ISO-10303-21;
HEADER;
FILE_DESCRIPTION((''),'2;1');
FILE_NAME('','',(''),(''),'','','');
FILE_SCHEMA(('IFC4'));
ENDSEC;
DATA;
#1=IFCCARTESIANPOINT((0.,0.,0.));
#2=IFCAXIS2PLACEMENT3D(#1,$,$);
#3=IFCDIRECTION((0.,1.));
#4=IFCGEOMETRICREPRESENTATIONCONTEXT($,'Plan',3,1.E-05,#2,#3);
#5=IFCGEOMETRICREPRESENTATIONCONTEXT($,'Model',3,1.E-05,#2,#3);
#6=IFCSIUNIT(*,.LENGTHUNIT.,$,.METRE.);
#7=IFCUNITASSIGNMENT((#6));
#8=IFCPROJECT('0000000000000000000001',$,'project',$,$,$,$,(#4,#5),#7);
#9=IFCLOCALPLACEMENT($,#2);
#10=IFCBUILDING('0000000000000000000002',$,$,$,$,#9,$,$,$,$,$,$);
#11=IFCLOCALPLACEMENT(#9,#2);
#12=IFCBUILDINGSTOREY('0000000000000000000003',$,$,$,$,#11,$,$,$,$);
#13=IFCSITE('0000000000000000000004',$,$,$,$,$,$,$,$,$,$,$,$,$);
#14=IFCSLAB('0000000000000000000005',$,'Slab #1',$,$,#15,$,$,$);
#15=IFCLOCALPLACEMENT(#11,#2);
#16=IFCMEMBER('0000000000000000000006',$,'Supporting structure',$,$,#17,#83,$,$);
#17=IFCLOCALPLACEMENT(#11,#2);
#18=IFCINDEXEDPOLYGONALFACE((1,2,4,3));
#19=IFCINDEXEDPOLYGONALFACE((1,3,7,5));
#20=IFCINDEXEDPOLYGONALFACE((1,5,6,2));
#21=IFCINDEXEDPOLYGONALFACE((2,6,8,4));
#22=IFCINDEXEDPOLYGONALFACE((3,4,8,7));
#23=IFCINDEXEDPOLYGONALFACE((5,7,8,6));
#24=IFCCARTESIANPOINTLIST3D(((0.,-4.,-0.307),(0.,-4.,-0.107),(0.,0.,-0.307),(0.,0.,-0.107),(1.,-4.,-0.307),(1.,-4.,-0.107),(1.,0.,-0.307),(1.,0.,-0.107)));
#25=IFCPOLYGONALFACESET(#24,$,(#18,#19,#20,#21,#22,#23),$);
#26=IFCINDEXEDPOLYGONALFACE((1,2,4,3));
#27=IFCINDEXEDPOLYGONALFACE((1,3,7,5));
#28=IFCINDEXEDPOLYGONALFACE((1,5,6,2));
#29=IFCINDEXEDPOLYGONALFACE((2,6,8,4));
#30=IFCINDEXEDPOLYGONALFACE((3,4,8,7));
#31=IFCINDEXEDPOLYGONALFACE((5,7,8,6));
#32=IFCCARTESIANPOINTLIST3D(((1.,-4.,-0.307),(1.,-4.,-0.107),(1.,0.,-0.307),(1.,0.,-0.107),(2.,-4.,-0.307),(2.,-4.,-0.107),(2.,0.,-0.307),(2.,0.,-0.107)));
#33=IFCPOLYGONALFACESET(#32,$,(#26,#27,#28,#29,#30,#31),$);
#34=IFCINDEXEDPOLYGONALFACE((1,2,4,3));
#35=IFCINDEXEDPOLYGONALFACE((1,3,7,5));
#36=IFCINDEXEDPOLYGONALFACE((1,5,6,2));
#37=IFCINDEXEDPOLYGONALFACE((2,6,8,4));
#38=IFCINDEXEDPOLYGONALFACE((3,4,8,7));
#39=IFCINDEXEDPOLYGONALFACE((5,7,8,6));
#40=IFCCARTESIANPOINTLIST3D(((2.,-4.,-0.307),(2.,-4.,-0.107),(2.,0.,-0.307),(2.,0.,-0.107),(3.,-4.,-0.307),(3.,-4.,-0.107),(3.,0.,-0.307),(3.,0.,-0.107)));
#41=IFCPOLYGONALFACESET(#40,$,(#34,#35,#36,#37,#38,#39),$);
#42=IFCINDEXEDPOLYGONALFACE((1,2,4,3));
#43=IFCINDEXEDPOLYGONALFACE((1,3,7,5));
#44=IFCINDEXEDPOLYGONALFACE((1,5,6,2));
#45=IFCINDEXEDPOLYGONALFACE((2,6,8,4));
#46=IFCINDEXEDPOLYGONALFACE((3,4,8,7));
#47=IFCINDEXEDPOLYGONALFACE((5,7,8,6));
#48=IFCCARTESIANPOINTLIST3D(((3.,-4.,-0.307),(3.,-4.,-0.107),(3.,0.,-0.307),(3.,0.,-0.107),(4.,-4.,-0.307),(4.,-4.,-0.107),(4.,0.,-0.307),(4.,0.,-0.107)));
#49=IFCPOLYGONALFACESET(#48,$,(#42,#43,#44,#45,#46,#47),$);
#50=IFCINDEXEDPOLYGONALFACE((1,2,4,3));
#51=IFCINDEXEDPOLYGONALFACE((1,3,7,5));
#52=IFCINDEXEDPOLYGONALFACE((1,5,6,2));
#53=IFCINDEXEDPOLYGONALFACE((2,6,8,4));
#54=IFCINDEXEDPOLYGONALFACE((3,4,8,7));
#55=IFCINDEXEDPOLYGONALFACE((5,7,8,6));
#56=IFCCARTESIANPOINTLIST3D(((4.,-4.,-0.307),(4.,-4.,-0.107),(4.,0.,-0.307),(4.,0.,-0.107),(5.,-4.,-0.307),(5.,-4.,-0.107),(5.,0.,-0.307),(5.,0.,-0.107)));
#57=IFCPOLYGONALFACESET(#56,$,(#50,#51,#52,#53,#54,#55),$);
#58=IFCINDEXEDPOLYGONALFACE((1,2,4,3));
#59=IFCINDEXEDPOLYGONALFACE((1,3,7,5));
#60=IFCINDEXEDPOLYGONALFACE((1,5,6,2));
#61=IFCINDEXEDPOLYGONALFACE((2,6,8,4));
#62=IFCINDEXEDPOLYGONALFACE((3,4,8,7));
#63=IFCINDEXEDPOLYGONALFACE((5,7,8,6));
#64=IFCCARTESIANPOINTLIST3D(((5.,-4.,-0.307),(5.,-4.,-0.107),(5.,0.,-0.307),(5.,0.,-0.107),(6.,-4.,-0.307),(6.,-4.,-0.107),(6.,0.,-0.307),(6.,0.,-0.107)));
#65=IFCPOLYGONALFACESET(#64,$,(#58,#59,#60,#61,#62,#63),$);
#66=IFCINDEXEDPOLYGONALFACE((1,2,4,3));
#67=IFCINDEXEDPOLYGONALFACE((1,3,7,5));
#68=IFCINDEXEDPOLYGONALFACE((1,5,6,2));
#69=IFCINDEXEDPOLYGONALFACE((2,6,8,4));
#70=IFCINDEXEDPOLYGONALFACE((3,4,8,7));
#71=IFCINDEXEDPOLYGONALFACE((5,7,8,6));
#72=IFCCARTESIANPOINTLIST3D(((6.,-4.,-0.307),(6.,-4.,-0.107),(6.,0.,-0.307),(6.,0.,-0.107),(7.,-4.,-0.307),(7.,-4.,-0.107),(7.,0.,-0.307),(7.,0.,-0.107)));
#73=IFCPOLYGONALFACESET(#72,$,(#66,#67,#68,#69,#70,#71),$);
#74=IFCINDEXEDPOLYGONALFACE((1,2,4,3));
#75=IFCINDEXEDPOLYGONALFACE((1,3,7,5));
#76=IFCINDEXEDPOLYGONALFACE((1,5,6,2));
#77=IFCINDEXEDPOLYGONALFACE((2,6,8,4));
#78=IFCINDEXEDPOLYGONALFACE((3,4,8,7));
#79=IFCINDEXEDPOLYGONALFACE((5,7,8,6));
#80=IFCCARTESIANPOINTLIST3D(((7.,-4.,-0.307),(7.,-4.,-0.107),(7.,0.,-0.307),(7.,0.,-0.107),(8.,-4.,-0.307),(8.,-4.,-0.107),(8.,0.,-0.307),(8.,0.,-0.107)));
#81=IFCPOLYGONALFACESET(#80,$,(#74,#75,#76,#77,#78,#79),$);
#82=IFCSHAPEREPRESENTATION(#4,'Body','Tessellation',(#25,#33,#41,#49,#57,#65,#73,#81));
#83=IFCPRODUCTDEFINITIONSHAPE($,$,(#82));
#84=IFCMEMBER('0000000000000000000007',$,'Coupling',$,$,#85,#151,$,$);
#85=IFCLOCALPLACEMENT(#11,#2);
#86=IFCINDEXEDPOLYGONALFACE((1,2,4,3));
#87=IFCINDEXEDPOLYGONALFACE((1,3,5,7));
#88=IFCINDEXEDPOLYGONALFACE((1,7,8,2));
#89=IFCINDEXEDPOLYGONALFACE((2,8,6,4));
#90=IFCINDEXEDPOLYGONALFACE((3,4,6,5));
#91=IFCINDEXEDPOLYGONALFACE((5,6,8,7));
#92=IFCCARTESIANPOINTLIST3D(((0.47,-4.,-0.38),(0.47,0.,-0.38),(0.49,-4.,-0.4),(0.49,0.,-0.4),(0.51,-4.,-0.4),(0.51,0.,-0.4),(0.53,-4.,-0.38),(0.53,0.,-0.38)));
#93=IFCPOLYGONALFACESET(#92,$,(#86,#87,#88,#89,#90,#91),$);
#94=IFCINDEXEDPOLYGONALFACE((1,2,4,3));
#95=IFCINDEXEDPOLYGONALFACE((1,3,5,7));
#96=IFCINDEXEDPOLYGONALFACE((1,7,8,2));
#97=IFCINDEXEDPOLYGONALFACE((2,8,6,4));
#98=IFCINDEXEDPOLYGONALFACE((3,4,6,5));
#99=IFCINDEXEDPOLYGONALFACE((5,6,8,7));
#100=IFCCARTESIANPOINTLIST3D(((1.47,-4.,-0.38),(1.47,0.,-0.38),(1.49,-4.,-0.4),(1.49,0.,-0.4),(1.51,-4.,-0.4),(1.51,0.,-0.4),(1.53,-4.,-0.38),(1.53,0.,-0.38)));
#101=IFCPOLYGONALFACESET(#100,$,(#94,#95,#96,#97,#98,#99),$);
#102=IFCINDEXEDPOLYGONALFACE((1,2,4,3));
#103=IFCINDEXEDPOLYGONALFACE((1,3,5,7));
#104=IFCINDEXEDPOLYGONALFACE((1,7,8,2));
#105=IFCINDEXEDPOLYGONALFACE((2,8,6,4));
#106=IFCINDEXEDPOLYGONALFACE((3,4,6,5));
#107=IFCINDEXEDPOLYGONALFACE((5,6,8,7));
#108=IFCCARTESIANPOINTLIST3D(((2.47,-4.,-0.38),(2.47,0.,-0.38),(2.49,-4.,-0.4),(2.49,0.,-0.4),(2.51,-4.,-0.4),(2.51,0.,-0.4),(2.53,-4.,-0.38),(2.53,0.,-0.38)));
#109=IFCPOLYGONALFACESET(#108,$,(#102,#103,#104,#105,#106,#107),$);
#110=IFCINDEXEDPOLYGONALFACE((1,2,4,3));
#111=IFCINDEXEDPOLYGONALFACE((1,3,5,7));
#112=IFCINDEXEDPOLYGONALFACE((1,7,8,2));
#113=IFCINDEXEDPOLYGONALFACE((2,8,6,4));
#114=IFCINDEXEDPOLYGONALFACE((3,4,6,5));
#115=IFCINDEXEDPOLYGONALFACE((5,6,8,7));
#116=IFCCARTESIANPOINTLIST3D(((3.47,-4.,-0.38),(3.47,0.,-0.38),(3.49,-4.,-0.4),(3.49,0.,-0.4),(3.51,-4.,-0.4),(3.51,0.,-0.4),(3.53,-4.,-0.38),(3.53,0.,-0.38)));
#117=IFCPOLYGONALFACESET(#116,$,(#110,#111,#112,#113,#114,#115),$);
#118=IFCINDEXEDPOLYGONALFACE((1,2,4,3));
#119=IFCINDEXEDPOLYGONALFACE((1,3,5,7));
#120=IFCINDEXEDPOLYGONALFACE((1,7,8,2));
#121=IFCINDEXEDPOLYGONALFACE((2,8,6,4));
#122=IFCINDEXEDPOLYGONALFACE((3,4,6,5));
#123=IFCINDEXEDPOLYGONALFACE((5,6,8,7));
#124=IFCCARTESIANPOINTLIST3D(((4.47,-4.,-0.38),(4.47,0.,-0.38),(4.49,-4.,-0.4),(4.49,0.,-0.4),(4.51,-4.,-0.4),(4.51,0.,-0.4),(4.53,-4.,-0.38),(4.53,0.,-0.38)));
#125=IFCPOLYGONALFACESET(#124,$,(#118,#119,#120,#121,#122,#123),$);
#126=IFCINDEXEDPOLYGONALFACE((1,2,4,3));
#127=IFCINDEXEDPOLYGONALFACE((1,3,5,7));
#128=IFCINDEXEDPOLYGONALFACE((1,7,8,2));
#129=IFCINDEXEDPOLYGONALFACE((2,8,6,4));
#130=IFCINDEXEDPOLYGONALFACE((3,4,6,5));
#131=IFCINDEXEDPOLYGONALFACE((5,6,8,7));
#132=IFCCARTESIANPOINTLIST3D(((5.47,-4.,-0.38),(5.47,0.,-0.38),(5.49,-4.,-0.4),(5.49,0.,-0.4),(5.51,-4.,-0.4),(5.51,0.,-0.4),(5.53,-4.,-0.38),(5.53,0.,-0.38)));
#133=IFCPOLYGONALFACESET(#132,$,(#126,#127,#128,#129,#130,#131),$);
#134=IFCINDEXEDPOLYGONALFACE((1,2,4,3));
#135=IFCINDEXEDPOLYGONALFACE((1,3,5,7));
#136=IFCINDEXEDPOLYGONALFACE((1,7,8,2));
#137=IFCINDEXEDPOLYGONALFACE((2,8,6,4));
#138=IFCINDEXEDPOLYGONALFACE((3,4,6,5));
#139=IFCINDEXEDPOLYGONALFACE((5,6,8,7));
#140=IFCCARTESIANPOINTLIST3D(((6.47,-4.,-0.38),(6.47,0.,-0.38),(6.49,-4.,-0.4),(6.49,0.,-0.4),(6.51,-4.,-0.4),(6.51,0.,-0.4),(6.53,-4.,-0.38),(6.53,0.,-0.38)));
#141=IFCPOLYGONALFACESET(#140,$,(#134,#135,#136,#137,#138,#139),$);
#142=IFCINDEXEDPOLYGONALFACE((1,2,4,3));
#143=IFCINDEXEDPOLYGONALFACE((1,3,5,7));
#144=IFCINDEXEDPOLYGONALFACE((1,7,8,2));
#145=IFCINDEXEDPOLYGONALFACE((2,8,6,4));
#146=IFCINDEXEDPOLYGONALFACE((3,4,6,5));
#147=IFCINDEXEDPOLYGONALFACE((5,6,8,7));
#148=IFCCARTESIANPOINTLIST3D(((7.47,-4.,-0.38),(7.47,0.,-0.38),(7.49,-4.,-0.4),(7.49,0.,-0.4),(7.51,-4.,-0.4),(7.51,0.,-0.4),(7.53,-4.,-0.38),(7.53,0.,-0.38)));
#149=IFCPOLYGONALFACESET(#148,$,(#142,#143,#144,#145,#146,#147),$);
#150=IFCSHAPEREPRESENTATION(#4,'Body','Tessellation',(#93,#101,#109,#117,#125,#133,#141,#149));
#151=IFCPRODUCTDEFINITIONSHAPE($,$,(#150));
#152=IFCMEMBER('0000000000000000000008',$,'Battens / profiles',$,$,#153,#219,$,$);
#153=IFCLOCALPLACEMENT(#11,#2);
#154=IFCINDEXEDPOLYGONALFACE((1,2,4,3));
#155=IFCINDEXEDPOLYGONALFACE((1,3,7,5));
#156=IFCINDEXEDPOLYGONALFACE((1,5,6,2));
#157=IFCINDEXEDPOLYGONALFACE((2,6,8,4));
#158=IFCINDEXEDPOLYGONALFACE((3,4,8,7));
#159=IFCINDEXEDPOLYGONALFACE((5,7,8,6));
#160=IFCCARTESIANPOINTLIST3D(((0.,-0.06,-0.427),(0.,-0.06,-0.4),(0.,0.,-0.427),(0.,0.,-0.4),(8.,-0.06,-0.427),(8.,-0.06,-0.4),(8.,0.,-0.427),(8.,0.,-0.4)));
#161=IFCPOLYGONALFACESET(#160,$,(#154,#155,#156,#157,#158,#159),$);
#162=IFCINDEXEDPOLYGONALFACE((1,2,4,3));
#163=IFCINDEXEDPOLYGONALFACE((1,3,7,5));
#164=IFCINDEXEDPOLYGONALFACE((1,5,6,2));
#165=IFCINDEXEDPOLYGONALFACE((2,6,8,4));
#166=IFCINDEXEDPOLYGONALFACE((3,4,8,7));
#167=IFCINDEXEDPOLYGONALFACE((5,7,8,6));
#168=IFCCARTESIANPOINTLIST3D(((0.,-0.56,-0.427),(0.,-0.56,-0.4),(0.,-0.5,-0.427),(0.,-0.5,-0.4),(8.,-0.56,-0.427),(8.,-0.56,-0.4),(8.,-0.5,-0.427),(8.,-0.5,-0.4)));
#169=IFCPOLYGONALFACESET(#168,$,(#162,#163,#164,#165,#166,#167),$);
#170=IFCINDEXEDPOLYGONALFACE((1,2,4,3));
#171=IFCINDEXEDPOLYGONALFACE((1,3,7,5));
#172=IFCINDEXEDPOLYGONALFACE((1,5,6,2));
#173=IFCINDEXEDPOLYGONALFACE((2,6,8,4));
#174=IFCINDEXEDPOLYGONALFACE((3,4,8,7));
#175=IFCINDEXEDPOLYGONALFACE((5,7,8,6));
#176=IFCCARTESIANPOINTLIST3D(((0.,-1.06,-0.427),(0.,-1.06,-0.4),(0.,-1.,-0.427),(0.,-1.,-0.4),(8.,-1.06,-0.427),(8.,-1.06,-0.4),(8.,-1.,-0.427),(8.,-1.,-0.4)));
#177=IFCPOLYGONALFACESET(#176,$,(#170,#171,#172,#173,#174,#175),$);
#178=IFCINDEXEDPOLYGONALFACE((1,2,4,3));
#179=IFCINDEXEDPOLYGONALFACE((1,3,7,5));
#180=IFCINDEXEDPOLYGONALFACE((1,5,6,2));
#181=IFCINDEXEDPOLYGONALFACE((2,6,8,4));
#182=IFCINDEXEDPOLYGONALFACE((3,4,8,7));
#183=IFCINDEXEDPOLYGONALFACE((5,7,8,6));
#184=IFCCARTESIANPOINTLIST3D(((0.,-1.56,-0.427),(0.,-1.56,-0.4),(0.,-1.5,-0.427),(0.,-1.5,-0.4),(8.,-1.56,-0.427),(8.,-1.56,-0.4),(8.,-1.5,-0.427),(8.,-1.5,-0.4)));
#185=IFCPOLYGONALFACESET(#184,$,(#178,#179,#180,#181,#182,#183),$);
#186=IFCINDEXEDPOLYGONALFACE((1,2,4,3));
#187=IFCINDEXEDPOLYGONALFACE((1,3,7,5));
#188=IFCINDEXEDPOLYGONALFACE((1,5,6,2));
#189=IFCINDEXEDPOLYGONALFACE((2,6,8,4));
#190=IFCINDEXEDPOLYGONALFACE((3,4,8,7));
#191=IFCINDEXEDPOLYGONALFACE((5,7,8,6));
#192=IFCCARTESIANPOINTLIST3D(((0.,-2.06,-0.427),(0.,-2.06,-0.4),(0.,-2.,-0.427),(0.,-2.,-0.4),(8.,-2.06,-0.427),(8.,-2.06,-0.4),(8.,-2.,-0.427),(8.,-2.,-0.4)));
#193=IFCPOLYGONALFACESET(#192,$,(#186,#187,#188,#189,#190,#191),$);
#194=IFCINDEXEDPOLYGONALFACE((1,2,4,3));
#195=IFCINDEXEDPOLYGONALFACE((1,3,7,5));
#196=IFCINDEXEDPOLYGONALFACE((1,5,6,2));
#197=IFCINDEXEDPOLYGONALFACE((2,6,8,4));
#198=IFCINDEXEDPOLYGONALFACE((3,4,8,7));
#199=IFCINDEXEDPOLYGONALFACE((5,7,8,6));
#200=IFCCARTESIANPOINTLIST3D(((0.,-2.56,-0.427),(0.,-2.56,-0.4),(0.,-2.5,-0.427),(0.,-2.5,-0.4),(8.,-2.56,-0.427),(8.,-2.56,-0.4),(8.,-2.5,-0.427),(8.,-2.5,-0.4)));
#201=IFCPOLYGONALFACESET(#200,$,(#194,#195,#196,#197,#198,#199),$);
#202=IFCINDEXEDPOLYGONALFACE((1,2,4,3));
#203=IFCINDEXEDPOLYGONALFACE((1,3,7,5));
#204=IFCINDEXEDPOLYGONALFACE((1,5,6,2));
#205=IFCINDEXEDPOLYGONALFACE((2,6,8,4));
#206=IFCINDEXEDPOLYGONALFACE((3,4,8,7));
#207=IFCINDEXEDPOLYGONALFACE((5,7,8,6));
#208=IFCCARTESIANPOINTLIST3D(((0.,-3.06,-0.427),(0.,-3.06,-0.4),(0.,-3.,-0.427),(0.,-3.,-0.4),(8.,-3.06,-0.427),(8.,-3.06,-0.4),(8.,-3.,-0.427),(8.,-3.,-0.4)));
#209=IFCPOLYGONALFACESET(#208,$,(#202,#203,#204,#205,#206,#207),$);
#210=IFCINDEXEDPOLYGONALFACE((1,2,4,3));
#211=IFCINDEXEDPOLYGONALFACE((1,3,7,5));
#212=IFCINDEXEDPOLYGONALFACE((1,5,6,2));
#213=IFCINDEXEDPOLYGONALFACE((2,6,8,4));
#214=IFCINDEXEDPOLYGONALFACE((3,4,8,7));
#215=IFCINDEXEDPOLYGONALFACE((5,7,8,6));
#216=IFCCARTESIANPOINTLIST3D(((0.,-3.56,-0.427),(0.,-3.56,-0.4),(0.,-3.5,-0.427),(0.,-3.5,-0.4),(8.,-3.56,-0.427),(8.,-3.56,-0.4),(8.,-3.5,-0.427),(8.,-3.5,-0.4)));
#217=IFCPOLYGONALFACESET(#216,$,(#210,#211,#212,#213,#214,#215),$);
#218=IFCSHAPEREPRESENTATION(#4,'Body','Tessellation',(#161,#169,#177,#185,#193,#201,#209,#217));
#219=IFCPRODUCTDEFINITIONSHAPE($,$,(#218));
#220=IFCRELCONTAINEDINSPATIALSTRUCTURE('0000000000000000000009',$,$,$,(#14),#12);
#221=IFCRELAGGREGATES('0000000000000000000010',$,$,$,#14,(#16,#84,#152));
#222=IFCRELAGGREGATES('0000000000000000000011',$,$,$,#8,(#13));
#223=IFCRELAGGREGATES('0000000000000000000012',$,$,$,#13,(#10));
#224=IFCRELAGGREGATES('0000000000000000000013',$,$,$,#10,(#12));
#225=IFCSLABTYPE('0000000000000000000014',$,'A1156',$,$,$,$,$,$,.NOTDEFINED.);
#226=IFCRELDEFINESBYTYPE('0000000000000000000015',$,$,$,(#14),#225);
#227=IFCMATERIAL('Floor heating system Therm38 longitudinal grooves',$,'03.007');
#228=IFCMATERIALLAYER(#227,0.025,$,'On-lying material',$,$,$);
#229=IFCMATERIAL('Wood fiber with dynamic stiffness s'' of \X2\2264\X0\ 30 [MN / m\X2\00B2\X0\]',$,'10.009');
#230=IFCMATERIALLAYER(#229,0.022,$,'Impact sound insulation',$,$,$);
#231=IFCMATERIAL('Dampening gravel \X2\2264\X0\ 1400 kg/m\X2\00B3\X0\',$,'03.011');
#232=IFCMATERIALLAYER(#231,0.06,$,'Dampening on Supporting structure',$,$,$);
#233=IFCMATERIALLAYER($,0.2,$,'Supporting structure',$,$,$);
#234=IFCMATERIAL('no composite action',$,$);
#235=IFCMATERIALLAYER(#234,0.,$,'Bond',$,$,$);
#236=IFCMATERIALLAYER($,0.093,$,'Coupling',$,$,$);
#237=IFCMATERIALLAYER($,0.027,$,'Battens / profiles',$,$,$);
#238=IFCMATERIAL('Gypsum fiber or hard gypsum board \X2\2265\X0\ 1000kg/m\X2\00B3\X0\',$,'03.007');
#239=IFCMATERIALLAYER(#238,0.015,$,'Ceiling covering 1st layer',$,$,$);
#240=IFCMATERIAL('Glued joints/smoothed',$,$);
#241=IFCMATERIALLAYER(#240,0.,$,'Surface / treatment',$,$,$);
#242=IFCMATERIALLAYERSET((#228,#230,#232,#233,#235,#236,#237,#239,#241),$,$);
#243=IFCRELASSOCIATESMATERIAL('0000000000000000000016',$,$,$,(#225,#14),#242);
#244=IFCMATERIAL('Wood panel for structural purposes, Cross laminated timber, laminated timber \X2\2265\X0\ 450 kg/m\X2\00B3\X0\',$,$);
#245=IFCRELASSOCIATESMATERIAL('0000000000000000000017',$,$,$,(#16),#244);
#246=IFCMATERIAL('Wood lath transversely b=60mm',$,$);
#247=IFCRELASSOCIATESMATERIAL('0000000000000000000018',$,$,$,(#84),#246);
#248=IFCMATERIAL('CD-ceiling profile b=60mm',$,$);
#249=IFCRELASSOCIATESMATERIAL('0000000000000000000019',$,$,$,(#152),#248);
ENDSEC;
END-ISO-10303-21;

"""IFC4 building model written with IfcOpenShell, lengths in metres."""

from ifc_helpers import new_model, si_unit, direction, frame, frame_2d, origin, place, context, project, spatial, polyline, rectangle, outline, extrude, material, layer, layer_set, type_object, element, aggregate, save


model = new_model("IFC4")

# Units and contexts
plan_context = context("Plan", 3, precision=1e-05, world=origin(), true_north=direction((0.0, 1.0)))
model_context = context("Model", 3, precision=1e-05, world=origin(), true_north=direction((0.0, 1.0)))
ifc_project = project(units=[si_unit("LENGTHUNIT", "METRE")], contexts=[plan_context, model_context])

# Site, building, storey
site = spatial("IfcSite", under=ifc_project)
building_placement = place(None, origin())
building = spatial("IfcBuilding", under=site, at=building_placement)
storey_placement = place(building_placement, origin())
storey = spatial("IfcBuildingStorey", under=building, at=storey_placement)

# Slab, members
ifc_material_1 = material(Name="Floor heating system Therm38 longitudinal grooves", Category="03.007")
ifc_layer_1 = layer(ifc_material_1, 0.025, Name="On-lying material")
ifc_material_2 = material(Name="Wood fiber with dynamic stiffness s' of ≤ 30 [MN / m²]", Category="10.009")
ifc_layer_2 = layer(ifc_material_2, 0.022, Name="Impact sound insulation")
ifc_material_3 = material(Name="Dampening gravel ≤ 1400 kg/m³", Category="03.011")
ifc_layer_3 = layer(ifc_material_3, 0.06, Name="Dampening on Supporting structure")
ifc_layer_4 = layer(None, 0.2, Name="Supporting structure")
ifc_material_4 = material(Name="no composite action")
ifc_layer_5 = layer(ifc_material_4, 0.0, Name="Bond")
ifc_layer_6 = layer(None, 0.093, Name="Coupling")
ifc_layer_7 = layer(None, 0.027, Name="Battens / profiles")
ifc_material_5 = material(Name="Gypsum fiber or hard gypsum board ≥ 1000kg/m³", Category="03.007")
ifc_layer_8 = layer(ifc_material_5, 0.015, Name="Ceiling covering 1st layer")
ifc_material_6 = material(Name="Glued joints/smoothed")
ifc_layer_9 = layer(ifc_material_6, 0.0, Name="Surface / treatment")
ifc_layer_set = layer_set([ifc_layer_1, ifc_layer_2, ifc_layer_3, ifc_layer_4, ifc_layer_5, ifc_layer_6, ifc_layer_7, ifc_layer_8, ifc_layer_9])
slab_type = type_object("IfcSlabType", Name="A1156", PredefinedType="NOTDEFINED", material=ifc_layer_set)
slab_placement = place(None, frame((0.0, 0.0, 0.0), z_axis=(0.0, 0.0, -1.0), x_axis=(1.0, 0.0, 0.0)))
slab = element("IfcSlab", 1, at=slab_placement, inside=storey, type_object=slab_type, material=ifc_layer_set, Name="Slab #1")
ifc_material_7 = material(Name="Wood panel for structural purposes, Cross laminated timber, laminated timber ≥ 450 kg/m³")
member_1_placement = place(slab_placement, origin())
member_1 = element("IfcMember", 2, at=member_1_placement, material=ifc_material_7, Name="Supporting structure", context=plan_context, shape_type="SweptSolid", body=[
    extrude(rectangle(XDim=1.0, YDim=0.2, at=frame_2d((0.5, 0.1), x_axis=(1.0, 0.0))), frame((0.0, 4.0, 0.107), z_axis=(0.0, -1.0, 0.0), x_axis=(1.0, 0.0, 0.0)), (0.0, 0.0, 1.0), 4.0),
    extrude(rectangle(XDim=1.0, YDim=0.2, at=frame_2d((0.5, 0.1), x_axis=(1.0, 0.0))), frame((1.0, 4.0, 0.107), z_axis=(0.0, -1.0, 0.0), x_axis=(1.0, 0.0, 0.0)), (0.0, 0.0, 1.0), 4.0),
    extrude(rectangle(XDim=1.0, YDim=0.2, at=frame_2d((0.5, 0.1), x_axis=(1.0, 0.0))), frame((2.0, 4.0, 0.107), z_axis=(0.0, -1.0, 0.0), x_axis=(1.0, 0.0, 0.0)), (0.0, 0.0, 1.0), 4.0),
    extrude(rectangle(XDim=1.0, YDim=0.2, at=frame_2d((0.5, 0.1), x_axis=(1.0, 0.0))), frame((3.0, 4.0, 0.107), z_axis=(0.0, -1.0, 0.0), x_axis=(1.0, 0.0, 0.0)), (0.0, 0.0, 1.0), 4.0),
    extrude(rectangle(XDim=1.0, YDim=0.2, at=frame_2d((0.5, 0.1), x_axis=(1.0, 0.0))), frame((4.0, 4.0, 0.107), z_axis=(0.0, -1.0, 0.0), x_axis=(1.0, 0.0, 0.0)), (0.0, 0.0, 1.0), 4.0),
    extrude(rectangle(XDim=1.0, YDim=0.2, at=frame_2d((0.5, 0.1), x_axis=(1.0, 0.0))), frame((5.0, 4.0, 0.107), z_axis=(0.0, -1.0, 0.0), x_axis=(1.0, 0.0, 0.0)), (0.0, 0.0, 1.0), 4.0),
    extrude(rectangle(XDim=1.0, YDim=0.2, at=frame_2d((0.5, 0.1), x_axis=(1.0, 0.0))), frame((6.0, 4.0, 0.107), z_axis=(0.0, -1.0, 0.0), x_axis=(1.0, 0.0, 0.0)), (0.0, 0.0, 1.0), 4.0),
    extrude(rectangle(XDim=1.0, YDim=0.2, at=frame_2d((0.5, 0.1), x_axis=(1.0, 0.0))), frame((7.0, 4.0, 0.107), z_axis=(0.0, -1.0, 0.0), x_axis=(1.0, 0.0, 0.0)), (0.0, 0.0, 1.0), 4.0),
])
ifc_material_8 = material(Name="Wood lath transversely b=60mm")
member_2_placement = place(slab_placement, origin())
member_2 = element("IfcMember", 3, at=member_2_placement, material=ifc_material_8, Name="Coupling", context=plan_context, shape_type="SweptSolid", body=[
    extrude(outline(polyline([(0.0, 0.0), (0.06, 0.0), (0.04, 0.02), (0.02, 0.02), (0.0, 0.0)])), frame((0.47, 4.0, 0.38), z_axis=(0.0, -1.0, 0.0), x_axis=(1.0, 0.0, 0.0)), (0.0, 0.0, 1.0), 4.0),
    extrude(outline(polyline([(0.0, 0.0), (0.06, 0.0), (0.04, 0.02), (0.02, 0.02), (0.0, 0.0)])), frame((1.47, 4.0, 0.38), z_axis=(0.0, -1.0, 0.0), x_axis=(1.0, 0.0, 0.0)), (0.0, 0.0, 1.0), 4.0),
    extrude(outline(polyline([(0.0, 0.0), (0.06, 0.0), (0.04, 0.02), (0.02, 0.02), (0.0, 0.0)])), frame((2.47, 4.0, 0.38), z_axis=(0.0, -1.0, 0.0), x_axis=(1.0, 0.0, 0.0)), (0.0, 0.0, 1.0), 4.0),
    extrude(outline(polyline([(0.0, 0.0), (0.06, 0.0), (0.04, 0.02), (0.02, 0.02), (0.0, 0.0)])), frame((3.47, 4.0, 0.38), z_axis=(0.0, -1.0, 0.0), x_axis=(1.0, 0.0, 0.0)), (0.0, 0.0, 1.0), 4.0),
    extrude(outline(polyline([(0.0, 0.0), (0.06, 0.0), (0.04, 0.02), (0.02, 0.02), (0.0, 0.0)])), frame((4.47, 4.0, 0.38), z_axis=(0.0, -1.0, 0.0), x_axis=(1.0, 0.0, 0.0)), (0.0, 0.0, 1.0), 4.0),
    extrude(outline(polyline([(0.0, 0.0), (0.06, 0.0), (0.04, 0.02), (0.02, 0.02), (0.0, 0.0)])), frame((5.47, 4.0, 0.38), z_axis=(0.0, -1.0, 0.0), x_axis=(1.0, 0.0, 0.0)), (0.0, 0.0, 1.0), 4.0),
    extrude(outline(polyline([(0.0, 0.0), (0.06, 0.0), (0.04, 0.02), (0.02, 0.02), (0.0, 0.0)])), frame((6.47, 4.0, 0.38), z_axis=(0.0, -1.0, 0.0), x_axis=(1.0, 0.0, 0.0)), (0.0, 0.0, 1.0), 4.0),
    extrude(outline(polyline([(0.0, 0.0), (0.06, 0.0), (0.04, 0.02), (0.02, 0.02), (0.0, 0.0)])), frame((7.47, 4.0, 0.38), z_axis=(0.0, -1.0, 0.0), x_axis=(1.0, 0.0, 0.0)), (0.0, 0.0, 1.0), 4.0),
])
ifc_material_9 = material(Name="CD-ceiling profile b=60mm")
member_3_placement = place(slab_placement, origin())
member_3 = element("IfcMember", 4, at=member_3_placement, material=ifc_material_9, Name="Battens / profiles", context=plan_context, shape_type="SweptSolid", body=[
    extrude(rectangle(XDim=0.06, YDim=0.027, at=frame_2d((0.03, 0.0135), x_axis=(1.0, 0.0))), frame((0.0, 0.0, 0.4), z_axis=(1.0, 0.0, 0.0), x_axis=(0.0, 1.0, 0.0)), (0.0, 0.0, 1.0), 8.0),
    extrude(rectangle(XDim=0.06, YDim=0.027, at=frame_2d((0.03, 0.0135), x_axis=(1.0, 0.0))), frame((0.0, 0.5, 0.4), z_axis=(1.0, 0.0, 0.0), x_axis=(0.0, 1.0, 0.0)), (0.0, 0.0, 1.0), 8.0),
    extrude(rectangle(XDim=0.06, YDim=0.027, at=frame_2d((0.03, 0.0135), x_axis=(1.0, 0.0))), frame((0.0, 1.0, 0.4), z_axis=(1.0, 0.0, 0.0), x_axis=(0.0, 1.0, 0.0)), (0.0, 0.0, 1.0), 8.0),
    extrude(rectangle(XDim=0.06, YDim=0.027, at=frame_2d((0.03, 0.0135), x_axis=(1.0, 0.0))), frame((0.0, 1.5, 0.4), z_axis=(1.0, 0.0, 0.0), x_axis=(0.0, 1.0, 0.0)), (0.0, 0.0, 1.0), 8.0),
    extrude(rectangle(XDim=0.06, YDim=0.027, at=frame_2d((0.03, 0.0135), x_axis=(1.0, 0.0))), frame((0.0, 2.0, 0.4), z_axis=(1.0, 0.0, 0.0), x_axis=(0.0, 1.0, 0.0)), (0.0, 0.0, 1.0), 8.0),
    extrude(rectangle(XDim=0.06, YDim=0.027, at=frame_2d((0.03, 0.0135), x_axis=(1.0, 0.0))), frame((0.0, 2.5, 0.4), z_axis=(1.0, 0.0, 0.0), x_axis=(0.0, 1.0, 0.0)), (0.0, 0.0, 1.0), 8.0),
    extrude(rectangle(XDim=0.06, YDim=0.027, at=frame_2d((0.03, 0.0135), x_axis=(1.0, 0.0))), frame((0.0, 3.0, 0.4), z_axis=(1.0, 0.0, 0.0), x_axis=(0.0, 1.0, 0.0)), (0.0, 0.0, 1.0), 8.0),
    extrude(rectangle(XDim=0.06, YDim=0.027, at=frame_2d((0.03, 0.0135), x_axis=(1.0, 0.0))), frame((0.0, 3.5, 0.4), z_axis=(1.0, 0.0, 0.0), x_axis=(0.0, 1.0, 0.0)), (0.0, 0.0, 1.0), 8.0),
])
aggregate(slab, [member_1, member_2, member_3])

save(model, "model.ifc")
